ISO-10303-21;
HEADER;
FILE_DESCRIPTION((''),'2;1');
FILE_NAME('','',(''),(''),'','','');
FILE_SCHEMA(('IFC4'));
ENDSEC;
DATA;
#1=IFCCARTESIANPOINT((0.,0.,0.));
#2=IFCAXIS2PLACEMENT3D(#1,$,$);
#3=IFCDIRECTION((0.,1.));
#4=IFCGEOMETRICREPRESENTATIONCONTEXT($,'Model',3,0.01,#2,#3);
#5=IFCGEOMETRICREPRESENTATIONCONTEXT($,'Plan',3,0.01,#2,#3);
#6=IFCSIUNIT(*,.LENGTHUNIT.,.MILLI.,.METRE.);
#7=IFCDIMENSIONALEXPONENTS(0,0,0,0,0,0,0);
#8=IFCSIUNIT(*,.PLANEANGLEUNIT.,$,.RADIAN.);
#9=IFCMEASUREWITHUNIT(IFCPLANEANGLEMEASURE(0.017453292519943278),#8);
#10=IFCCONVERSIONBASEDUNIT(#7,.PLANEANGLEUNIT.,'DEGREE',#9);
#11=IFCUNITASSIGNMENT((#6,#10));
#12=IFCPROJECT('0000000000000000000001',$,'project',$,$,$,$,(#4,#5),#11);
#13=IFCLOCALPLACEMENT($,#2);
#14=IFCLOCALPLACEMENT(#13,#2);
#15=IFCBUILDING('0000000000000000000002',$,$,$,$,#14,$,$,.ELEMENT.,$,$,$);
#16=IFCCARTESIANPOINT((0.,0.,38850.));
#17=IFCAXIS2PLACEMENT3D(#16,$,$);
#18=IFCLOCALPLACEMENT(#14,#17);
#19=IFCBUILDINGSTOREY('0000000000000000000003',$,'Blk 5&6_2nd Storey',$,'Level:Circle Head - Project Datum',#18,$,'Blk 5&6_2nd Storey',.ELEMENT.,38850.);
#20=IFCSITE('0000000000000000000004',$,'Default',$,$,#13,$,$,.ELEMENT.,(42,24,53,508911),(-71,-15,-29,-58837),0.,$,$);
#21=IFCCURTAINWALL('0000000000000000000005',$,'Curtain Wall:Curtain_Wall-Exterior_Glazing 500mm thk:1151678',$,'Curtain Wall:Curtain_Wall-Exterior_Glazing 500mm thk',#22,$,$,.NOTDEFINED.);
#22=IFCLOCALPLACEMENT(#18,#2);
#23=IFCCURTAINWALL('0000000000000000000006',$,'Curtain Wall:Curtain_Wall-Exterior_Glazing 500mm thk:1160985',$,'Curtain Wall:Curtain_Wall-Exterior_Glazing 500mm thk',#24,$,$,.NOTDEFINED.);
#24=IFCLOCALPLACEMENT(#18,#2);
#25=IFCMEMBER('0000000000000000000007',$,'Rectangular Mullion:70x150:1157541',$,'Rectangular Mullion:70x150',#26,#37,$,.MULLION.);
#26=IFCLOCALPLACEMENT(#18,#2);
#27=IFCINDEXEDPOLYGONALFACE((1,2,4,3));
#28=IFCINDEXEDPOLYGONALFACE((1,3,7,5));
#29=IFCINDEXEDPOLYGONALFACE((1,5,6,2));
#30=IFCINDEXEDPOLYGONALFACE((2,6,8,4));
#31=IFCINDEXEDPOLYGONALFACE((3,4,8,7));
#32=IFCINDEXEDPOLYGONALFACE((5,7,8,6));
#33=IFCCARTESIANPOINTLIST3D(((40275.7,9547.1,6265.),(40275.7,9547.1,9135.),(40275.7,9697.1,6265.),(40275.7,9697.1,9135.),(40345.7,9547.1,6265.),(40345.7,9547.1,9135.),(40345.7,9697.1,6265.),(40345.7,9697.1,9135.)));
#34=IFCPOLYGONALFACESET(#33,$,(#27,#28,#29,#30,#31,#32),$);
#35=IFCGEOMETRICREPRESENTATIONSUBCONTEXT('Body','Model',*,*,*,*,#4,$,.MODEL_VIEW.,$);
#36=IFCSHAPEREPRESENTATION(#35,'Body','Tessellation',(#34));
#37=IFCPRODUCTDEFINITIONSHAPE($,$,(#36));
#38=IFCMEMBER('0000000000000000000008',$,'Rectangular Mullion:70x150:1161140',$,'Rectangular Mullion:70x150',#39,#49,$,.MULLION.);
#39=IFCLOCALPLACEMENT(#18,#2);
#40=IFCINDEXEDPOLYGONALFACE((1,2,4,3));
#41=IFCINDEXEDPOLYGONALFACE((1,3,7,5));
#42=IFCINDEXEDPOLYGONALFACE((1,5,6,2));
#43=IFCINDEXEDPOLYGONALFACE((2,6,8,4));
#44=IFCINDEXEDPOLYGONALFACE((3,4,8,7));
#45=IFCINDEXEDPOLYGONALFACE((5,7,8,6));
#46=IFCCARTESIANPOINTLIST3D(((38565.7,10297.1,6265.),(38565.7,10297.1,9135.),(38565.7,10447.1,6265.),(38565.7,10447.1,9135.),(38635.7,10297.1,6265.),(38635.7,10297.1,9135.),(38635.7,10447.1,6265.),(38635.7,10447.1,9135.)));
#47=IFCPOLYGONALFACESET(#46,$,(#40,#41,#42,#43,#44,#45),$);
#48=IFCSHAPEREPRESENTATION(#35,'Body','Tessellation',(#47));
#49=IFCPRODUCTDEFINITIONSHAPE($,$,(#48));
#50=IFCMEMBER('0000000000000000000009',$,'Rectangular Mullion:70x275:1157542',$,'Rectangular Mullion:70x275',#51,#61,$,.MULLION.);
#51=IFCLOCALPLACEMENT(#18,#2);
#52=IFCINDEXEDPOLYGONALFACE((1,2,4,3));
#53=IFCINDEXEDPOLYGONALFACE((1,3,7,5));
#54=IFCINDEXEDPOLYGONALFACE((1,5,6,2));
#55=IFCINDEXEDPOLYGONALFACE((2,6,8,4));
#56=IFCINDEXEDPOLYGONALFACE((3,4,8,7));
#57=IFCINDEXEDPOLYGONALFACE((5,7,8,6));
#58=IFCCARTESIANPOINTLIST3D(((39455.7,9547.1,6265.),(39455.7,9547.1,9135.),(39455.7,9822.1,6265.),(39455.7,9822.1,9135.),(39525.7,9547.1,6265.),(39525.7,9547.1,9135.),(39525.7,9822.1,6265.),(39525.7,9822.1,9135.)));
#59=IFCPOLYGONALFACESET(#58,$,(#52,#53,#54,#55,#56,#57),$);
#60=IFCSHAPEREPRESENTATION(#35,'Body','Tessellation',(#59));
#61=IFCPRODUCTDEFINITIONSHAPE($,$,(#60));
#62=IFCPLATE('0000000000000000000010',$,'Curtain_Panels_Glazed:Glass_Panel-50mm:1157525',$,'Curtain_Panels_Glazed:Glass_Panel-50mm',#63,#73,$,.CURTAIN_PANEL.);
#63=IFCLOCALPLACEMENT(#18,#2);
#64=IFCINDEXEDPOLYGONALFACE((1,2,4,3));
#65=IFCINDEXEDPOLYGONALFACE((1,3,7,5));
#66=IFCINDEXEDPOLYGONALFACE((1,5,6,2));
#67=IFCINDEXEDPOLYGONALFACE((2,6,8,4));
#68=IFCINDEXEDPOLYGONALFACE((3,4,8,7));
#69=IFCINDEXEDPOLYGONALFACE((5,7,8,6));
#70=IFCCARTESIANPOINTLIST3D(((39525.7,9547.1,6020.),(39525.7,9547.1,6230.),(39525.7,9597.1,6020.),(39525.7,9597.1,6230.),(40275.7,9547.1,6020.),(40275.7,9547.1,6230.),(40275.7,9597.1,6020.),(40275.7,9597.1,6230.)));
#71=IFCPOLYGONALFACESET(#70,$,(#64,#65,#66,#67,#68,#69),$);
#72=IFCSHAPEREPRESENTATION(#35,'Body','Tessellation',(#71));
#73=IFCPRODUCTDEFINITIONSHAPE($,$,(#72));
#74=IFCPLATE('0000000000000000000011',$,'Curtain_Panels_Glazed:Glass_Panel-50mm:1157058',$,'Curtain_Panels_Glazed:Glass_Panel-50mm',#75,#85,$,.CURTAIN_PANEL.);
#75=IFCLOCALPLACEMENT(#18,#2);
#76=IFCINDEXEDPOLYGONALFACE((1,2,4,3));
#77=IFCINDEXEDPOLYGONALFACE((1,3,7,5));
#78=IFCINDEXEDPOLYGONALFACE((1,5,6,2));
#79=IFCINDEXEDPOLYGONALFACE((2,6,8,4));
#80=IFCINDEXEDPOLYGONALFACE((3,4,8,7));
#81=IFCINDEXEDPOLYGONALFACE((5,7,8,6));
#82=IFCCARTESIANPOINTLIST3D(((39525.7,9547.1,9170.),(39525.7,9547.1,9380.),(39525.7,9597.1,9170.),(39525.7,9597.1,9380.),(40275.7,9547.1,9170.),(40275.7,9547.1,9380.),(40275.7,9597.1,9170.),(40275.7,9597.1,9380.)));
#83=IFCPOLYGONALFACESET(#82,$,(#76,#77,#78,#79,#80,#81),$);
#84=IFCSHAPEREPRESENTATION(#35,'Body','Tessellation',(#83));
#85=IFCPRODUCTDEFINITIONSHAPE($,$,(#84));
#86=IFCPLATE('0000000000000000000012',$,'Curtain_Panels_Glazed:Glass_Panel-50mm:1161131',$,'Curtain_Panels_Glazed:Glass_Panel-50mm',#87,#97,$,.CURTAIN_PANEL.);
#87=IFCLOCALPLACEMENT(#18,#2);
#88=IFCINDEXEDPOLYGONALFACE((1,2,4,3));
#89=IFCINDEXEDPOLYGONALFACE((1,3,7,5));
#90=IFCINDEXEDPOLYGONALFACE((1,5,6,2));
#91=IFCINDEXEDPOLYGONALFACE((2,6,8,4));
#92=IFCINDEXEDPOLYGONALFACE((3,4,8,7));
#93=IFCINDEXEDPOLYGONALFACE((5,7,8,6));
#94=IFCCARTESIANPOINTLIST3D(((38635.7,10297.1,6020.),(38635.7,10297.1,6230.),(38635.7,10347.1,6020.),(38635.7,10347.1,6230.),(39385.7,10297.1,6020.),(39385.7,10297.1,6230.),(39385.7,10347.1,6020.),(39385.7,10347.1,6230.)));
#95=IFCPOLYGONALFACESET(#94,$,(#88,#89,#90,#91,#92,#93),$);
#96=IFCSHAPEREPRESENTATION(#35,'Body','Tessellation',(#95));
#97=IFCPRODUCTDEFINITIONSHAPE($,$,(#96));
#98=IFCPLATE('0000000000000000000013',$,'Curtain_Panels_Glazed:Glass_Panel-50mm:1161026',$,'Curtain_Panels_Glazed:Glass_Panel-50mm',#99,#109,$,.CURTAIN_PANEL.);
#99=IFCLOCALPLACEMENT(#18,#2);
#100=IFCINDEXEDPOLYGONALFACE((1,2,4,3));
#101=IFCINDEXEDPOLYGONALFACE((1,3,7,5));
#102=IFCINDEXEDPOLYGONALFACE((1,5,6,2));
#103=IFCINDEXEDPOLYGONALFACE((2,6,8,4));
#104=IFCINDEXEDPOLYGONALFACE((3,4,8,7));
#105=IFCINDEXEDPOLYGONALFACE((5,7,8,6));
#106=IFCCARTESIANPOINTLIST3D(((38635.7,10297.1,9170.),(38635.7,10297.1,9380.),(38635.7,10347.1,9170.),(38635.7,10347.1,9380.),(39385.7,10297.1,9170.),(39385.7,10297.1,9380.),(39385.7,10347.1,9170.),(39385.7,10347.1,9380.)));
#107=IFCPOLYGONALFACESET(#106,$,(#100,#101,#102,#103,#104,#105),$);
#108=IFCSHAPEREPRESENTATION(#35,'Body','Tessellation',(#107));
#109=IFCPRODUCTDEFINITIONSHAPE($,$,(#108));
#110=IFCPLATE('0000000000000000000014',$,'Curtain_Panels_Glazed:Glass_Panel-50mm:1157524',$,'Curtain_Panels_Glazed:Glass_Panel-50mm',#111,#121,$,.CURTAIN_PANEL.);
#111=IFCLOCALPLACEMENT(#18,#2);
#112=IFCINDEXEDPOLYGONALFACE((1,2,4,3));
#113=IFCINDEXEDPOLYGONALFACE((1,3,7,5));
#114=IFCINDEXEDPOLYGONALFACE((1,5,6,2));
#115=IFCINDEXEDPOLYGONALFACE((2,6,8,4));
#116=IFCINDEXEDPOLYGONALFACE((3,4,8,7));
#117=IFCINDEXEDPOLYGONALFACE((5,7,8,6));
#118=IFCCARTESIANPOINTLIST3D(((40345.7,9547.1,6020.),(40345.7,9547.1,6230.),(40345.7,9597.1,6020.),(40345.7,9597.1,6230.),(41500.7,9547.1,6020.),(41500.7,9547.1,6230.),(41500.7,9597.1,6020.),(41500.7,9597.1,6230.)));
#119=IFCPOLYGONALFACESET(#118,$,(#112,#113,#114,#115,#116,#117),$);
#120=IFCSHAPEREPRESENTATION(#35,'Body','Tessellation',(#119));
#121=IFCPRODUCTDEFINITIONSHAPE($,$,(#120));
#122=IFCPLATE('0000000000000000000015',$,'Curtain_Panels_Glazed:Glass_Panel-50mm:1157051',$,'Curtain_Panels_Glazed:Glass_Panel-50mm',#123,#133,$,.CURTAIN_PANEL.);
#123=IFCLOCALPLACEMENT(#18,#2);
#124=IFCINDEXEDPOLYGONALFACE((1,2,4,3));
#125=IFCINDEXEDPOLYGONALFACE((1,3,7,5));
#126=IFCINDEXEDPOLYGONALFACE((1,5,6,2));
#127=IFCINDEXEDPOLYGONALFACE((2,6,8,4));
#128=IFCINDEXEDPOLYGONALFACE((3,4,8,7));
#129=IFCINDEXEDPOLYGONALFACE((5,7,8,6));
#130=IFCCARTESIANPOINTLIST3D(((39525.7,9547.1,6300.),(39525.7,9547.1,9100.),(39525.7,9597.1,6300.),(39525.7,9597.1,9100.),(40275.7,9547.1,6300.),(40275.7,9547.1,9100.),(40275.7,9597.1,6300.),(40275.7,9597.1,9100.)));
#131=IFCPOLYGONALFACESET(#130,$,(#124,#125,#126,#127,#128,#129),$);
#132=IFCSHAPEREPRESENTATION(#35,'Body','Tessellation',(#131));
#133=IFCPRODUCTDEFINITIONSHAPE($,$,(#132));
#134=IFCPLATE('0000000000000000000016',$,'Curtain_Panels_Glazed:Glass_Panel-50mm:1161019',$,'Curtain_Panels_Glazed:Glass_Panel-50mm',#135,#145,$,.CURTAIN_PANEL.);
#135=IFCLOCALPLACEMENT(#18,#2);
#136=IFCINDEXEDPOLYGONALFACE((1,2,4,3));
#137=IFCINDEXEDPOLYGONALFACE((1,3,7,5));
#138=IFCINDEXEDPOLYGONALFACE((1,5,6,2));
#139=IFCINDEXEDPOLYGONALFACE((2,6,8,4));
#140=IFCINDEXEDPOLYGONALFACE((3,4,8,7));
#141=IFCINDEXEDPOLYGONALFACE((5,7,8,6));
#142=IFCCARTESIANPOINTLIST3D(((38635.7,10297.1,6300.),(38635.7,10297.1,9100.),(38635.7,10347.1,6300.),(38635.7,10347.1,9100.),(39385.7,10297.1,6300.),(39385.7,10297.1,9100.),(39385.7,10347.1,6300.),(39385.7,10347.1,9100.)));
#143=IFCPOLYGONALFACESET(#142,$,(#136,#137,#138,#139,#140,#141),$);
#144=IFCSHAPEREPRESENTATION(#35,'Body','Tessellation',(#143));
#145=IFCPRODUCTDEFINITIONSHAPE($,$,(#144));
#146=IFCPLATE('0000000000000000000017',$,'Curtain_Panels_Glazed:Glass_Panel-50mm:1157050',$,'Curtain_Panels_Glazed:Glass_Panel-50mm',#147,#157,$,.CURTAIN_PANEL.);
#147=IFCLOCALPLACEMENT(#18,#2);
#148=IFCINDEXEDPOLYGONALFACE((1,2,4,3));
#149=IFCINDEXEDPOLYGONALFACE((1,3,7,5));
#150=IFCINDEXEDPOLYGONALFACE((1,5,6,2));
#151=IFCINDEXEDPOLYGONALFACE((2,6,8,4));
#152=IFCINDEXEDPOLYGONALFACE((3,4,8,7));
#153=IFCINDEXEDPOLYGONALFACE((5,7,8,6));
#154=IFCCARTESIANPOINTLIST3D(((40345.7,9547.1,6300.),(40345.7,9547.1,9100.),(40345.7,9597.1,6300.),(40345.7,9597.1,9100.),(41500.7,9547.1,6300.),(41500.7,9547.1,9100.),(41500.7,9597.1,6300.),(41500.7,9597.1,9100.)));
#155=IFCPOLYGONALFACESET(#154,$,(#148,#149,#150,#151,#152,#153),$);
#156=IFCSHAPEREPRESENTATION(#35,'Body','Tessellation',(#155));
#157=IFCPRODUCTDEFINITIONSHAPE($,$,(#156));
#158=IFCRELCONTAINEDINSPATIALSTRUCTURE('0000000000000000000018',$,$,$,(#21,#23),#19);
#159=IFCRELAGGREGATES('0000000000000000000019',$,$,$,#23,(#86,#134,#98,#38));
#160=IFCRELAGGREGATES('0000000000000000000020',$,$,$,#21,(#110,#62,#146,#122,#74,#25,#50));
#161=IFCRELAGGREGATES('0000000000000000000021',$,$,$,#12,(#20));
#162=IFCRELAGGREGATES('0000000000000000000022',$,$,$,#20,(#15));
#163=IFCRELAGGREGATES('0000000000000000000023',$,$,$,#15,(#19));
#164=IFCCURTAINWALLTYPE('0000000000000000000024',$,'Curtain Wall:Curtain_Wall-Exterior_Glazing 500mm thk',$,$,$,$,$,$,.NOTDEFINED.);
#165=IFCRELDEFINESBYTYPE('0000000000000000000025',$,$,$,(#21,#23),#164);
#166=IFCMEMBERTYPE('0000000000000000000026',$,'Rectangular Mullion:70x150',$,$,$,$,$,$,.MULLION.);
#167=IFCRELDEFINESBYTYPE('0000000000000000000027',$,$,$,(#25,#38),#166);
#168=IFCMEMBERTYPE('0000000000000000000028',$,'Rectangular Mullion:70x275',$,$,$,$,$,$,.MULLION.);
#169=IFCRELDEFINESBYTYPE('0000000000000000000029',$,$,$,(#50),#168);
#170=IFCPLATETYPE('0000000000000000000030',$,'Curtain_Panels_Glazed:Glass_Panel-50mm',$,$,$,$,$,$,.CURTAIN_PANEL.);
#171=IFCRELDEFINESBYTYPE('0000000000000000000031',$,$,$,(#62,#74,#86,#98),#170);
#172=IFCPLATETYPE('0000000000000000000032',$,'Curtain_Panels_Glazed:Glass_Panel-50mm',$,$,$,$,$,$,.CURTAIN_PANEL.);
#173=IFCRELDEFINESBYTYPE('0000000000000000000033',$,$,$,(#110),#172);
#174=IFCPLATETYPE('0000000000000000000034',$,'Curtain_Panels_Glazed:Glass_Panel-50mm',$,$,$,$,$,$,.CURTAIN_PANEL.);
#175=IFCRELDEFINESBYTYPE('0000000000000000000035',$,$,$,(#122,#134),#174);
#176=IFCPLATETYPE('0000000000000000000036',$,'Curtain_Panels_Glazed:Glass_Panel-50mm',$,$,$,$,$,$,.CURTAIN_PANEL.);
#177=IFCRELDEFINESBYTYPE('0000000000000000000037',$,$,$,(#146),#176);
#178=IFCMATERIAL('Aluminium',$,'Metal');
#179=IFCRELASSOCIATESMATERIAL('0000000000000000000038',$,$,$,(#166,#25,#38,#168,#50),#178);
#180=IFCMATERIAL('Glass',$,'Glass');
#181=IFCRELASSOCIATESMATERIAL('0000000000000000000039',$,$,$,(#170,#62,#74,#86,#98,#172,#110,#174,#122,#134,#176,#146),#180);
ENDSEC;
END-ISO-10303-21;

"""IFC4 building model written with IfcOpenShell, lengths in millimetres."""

from ifc_helpers import new_model, entity, si_unit, converted_unit, direction, frame, origin, place, context, subcontext, project, spatial, indexed_curve, outline, extrude, source, transform, mapped, material, type_object, type_shapes, element, aggregate, save


model = new_model("IFC4")

# Units and contexts
model_context = context("Model", 3, precision=0.01, world=origin(), true_north=direction((0.0, 1.0)))
plan_context = context("Plan", 3, precision=0.01, world=origin(), true_north=direction((0.0, 1.0)))
body_context = subcontext(model_context, "Body", "Model", "MODEL_VIEW")
ifc_project = project(units=[si_unit("LENGTHUNIT", "METRE", prefix="MILLI"), converted_unit("PLANEANGLEUNIT", "DEGREE", entity("IfcPlaneAngleMeasure", 0.017453292519943278), si_unit("PLANEANGLEUNIT", "RADIAN"), dimensions=[0, 0, 0, 0, 0, 0, 0])], contexts=[model_context, plan_context])

# Site, building, storey
site_placement = place(None, origin())
site = spatial("IfcSite", under=ifc_project, at=site_placement, Name="Default", CompositionType="ELEMENT", RefLatitude=(42, 24, 53, 508911), RefLongitude=(-71, -15, -29, -58837), RefElevation=0.0)
building_placement = place(site_placement, origin())
building = spatial("IfcBuilding", under=site, at=building_placement, CompositionType="ELEMENT")
storey_placement = place(building_placement, frame((0.0, 0.0, 38850.0)))
storey = spatial("IfcBuildingStorey", under=building, at=storey_placement, Name="Blk 5&6_2nd Storey", ObjectType="Level:Circle Head - Project Datum", LongName="Blk 5&6_2nd Storey", CompositionType="ELEMENT", Elevation=38850.0)

# Curtain walls
curtain_wall_type = type_object("IfcCurtainWallType", Name="Curtain Wall:Curtain_Wall-Exterior_Glazing 500mm thk", PredefinedType="NOTDEFINED")
curtain_wall_1_placement = place(storey_placement, frame((0.0, 0.0, -38850.0)))
curtain_wall_1 = element("IfcCurtainWall", 1, at=curtain_wall_1_placement, inside=storey, type_object=curtain_wall_type, Name="Curtain Wall:Curtain_Wall-Exterior_Glazing 500mm thk:1151678", ObjectType="Curtain Wall:Curtain_Wall-Exterior_Glazing 500mm thk", PredefinedType="NOTDEFINED")
ifc_material_1 = material(Name="Aluminium", Category="Metal")
curtain_wall_2_placement = place(storey_placement, frame((0.0, 0.0, -38850.0)))
curtain_wall_2 = element("IfcCurtainWall", 2, at=curtain_wall_2_placement, inside=storey, type_object=curtain_wall_type, Name="Curtain Wall:Curtain_Wall-Exterior_Glazing 500mm thk:1160985", ObjectType="Curtain Wall:Curtain_Wall-Exterior_Glazing 500mm thk", PredefinedType="NOTDEFINED")

# Members
member_type_1 = type_object("IfcMemberType", Name="Rectangular Mullion:70x150", PredefinedType="MULLION", material=ifc_material_1)
shared_shape_1 = source(origin(), body_context, "Body", "SweptSolid", [
    extrude(outline(indexed_curve([(-35.0, -75.0), (35.0, -75.0), (35.0, 75.0), (-35.0, 75.0), (-35.0, -75.0)], self_intersect=False)), frame((0.0, -200.0, -2870.0), z_axis=(0.0, 0.0, 1.0), x_axis=(-1.0, 0.0, 0.0)), (0.0, 0.0, 1.0), 2870.0),
])
type_shapes(member_type_1, [shared_shape_1])
member_1_placement = place(curtain_wall_1_placement, frame((40310.7, 9822.1, 45115.0), z_axis=(0.0, 0.0, -1.0), x_axis=(-1.0, 0.0, 0.0)))
member_1 = element("IfcMember", 3, at=member_1_placement, type_object=member_type_1, material=ifc_material_1, Name="Rectangular Mullion:70x150:1157541", ObjectType="Rectangular Mullion:70x150", PredefinedType="MULLION", context=body_context, shape_type="MappedRepresentation", body=[
    mapped(shared_shape_1, transform((0.0, 0.0, 0.0), scale=1.0)),
])
member_2_placement = place(curtain_wall_2_placement, frame((38600.7, 10572.1, 45115.0), z_axis=(0.0, 0.0, -1.0), x_axis=(-1.0, 0.0, 0.0)))
member_2 = element("IfcMember", 4, at=member_2_placement, type_object=member_type_1, material=ifc_material_1, Name="Rectangular Mullion:70x150:1161140", ObjectType="Rectangular Mullion:70x150", PredefinedType="MULLION", context=body_context, shape_type="MappedRepresentation", body=[
    mapped(shared_shape_1, transform((0.0, 0.0, 0.0), scale=1.0)),
])
member_type_2 = type_object("IfcMemberType", Name="Rectangular Mullion:70x275", PredefinedType="MULLION", material=ifc_material_1)
shared_shape_2 = source(origin(), body_context, "Body", "SweptSolid", [
    extrude(outline(indexed_curve([(-35.0, -137.5), (35.0, -137.5), (35.0, 137.5), (-35.0, 137.5), (-35.0, -137.5)], self_intersect=False)), frame((-35.0, -137.5, -2870.0), z_axis=(0.0, 0.0, 1.0), x_axis=(-1.0, 0.0, 0.0)), (0.0, 0.0, 1.0), 2870.0),
])
type_shapes(member_type_2, [shared_shape_2])
member_3_placement = place(curtain_wall_1_placement, frame((39455.7, 9822.1, 45115.0), z_axis=(0.0, 0.0, -1.0), x_axis=(-1.0, 0.0, 0.0)))
member_3 = element("IfcMember", 5, at=member_3_placement, type_object=member_type_2, material=ifc_material_1, Name="Rectangular Mullion:70x275:1157542", ObjectType="Rectangular Mullion:70x275", PredefinedType="MULLION", context=body_context, shape_type="MappedRepresentation", body=[
    mapped(shared_shape_2, transform((0.0, 0.0, 0.0), scale=1.0)),
])

# Plates
ifc_material_2 = material(Name="Glass", Category="Glass")
plate_type_1 = type_object("IfcPlateType", Name="Curtain_Panels_Glazed:Glass_Panel-50mm", PredefinedType="CURTAIN_PANEL", material=ifc_material_2)
shared_shape_3 = source(origin(), body_context, "Body", "SweptSolid", [
    extrude(outline(indexed_curve([(-25.0, -375.0), (25.0, -375.0), (25.0, 375.0), (-25.0, 375.0), (-25.0, -375.0)], self_intersect=False)), frame((0.0, 250.0, 0.0), z_axis=(0.0, 0.0, 1.0), x_axis=(0.0, 1.0, 0.0)), (0.0, 0.0, 1.0), 210.0),
])
type_shapes(plate_type_1, [shared_shape_3])
plate_1_placement = place(curtain_wall_1_placement, frame((39900.7, 9822.1, 44870.0), z_axis=(0.0, 0.0, 1.0), x_axis=(-1.0, 0.0, 0.0)))
plate_1 = element("IfcPlate", 6, at=plate_1_placement, type_object=plate_type_1, material=ifc_material_2, Name="Curtain_Panels_Glazed:Glass_Panel-50mm:1157525", ObjectType="Curtain_Panels_Glazed:Glass_Panel-50mm", PredefinedType="CURTAIN_PANEL", context=body_context, shape_type="MappedRepresentation", body=[
    mapped(shared_shape_3, transform((0.0, 0.0, 0.0), scale=1.0)),
])
plate_2_placement = place(curtain_wall_1_placement, frame((39900.7, 9822.1, 48020.0), z_axis=(0.0, 0.0, 1.0), x_axis=(-1.0, 0.0, 0.0)))
plate_2 = element("IfcPlate", 7, at=plate_2_placement, type_object=plate_type_1, material=ifc_material_2, Name="Curtain_Panels_Glazed:Glass_Panel-50mm:1157058", ObjectType="Curtain_Panels_Glazed:Glass_Panel-50mm", PredefinedType="CURTAIN_PANEL", context=body_context, shape_type="MappedRepresentation", body=[
    mapped(shared_shape_3, transform((0.0, 0.0, 0.0), scale=1.0)),
])
plate_3_placement = place(curtain_wall_2_placement, frame((39010.7, 10572.1, 44870.0), z_axis=(0.0, 0.0, 1.0), x_axis=(-1.0, 0.0, 0.0)))
plate_3 = element("IfcPlate", 8, at=plate_3_placement, type_object=plate_type_1, material=ifc_material_2, Name="Curtain_Panels_Glazed:Glass_Panel-50mm:1161131", ObjectType="Curtain_Panels_Glazed:Glass_Panel-50mm", PredefinedType="CURTAIN_PANEL", context=body_context, shape_type="MappedRepresentation", body=[
    mapped(shared_shape_3, transform((0.0, 0.0, 0.0), scale=1.0)),
])
plate_4_placement = place(curtain_wall_2_placement, frame((39010.7, 10572.1, 48020.0), z_axis=(0.0, 0.0, 1.0), x_axis=(-1.0, 0.0, 0.0)))
plate_4 = element("IfcPlate", 9, at=plate_4_placement, type_object=plate_type_1, material=ifc_material_2, Name="Curtain_Panels_Glazed:Glass_Panel-50mm:1161026", ObjectType="Curtain_Panels_Glazed:Glass_Panel-50mm", PredefinedType="CURTAIN_PANEL", context=body_context, shape_type="MappedRepresentation", body=[
    mapped(shared_shape_3, transform((0.0, 0.0, 0.0), scale=1.0)),
])
plate_type_2 = type_object("IfcPlateType", Name="Curtain_Panels_Glazed:Glass_Panel-50mm", PredefinedType="CURTAIN_PANEL", material=ifc_material_2)
shared_shape_4 = source(origin(), body_context, "Body", "SweptSolid", [
    extrude(outline(indexed_curve([(-25.0, -577.5), (25.0, -577.5), (25.0, 577.5), (-25.0, 577.5), (-25.0, -577.5)], self_intersect=False)), frame((0.0, 250.0, 0.0), z_axis=(0.0, 0.0, 1.0), x_axis=(0.0, 1.0, 0.0)), (0.0, 0.0, 1.0), 210.0),
])
type_shapes(plate_type_2, [shared_shape_4])
plate_5_placement = place(curtain_wall_1_placement, frame((40923.2, 9822.1, 44870.0), z_axis=(0.0, 0.0, 1.0), x_axis=(-1.0, 0.0, 0.0)))
plate_5 = element("IfcPlate", 10, at=plate_5_placement, type_object=plate_type_2, material=ifc_material_2, Name="Curtain_Panels_Glazed:Glass_Panel-50mm:1157524", ObjectType="Curtain_Panels_Glazed:Glass_Panel-50mm", PredefinedType="CURTAIN_PANEL", context=body_context, shape_type="MappedRepresentation", body=[
    mapped(shared_shape_4, transform((0.0, 0.0, 0.0), scale=1.0)),
])
plate_type_3 = type_object("IfcPlateType", Name="Curtain_Panels_Glazed:Glass_Panel-50mm", PredefinedType="CURTAIN_PANEL", material=ifc_material_2)
shared_shape_5 = source(origin(), body_context, "Body", "SweptSolid", [
    extrude(outline(indexed_curve([(-25.0, -375.0), (25.0, -375.0), (25.0, 375.0), (-25.0, 375.0), (-25.0, -375.0)], self_intersect=False)), frame((0.0, 250.0, 0.0), z_axis=(0.0, 0.0, 1.0), x_axis=(0.0, 1.0, 0.0)), (0.0, 0.0, 1.0), 2800.0),
])
type_shapes(plate_type_3, [shared_shape_5])
plate_6_placement = place(curtain_wall_1_placement, frame((39900.7, 9822.1, 45150.0), z_axis=(0.0, 0.0, 1.0), x_axis=(-1.0, 0.0, 0.0)))
plate_6 = element("IfcPlate", 11, at=plate_6_placement, type_object=plate_type_3, material=ifc_material_2, Name="Curtain_Panels_Glazed:Glass_Panel-50mm:1157051", ObjectType="Curtain_Panels_Glazed:Glass_Panel-50mm", PredefinedType="CURTAIN_PANEL", context=body_context, shape_type="MappedRepresentation", body=[
    mapped(shared_shape_5, transform((0.0, 0.0, 0.0), scale=1.0)),
])
plate_7_placement = place(curtain_wall_2_placement, frame((39010.7, 10572.1, 45150.0), z_axis=(0.0, 0.0, 1.0), x_axis=(-1.0, 0.0, 0.0)))
plate_7 = element("IfcPlate", 12, at=plate_7_placement, type_object=plate_type_3, material=ifc_material_2, Name="Curtain_Panels_Glazed:Glass_Panel-50mm:1161019", ObjectType="Curtain_Panels_Glazed:Glass_Panel-50mm", PredefinedType="CURTAIN_PANEL", context=body_context, shape_type="MappedRepresentation", body=[
    mapped(shared_shape_5, transform((0.0, 0.0, 0.0), scale=1.0)),
])
aggregate(curtain_wall_2, [plate_3, plate_7, plate_4, member_2])
plate_type_4 = type_object("IfcPlateType", Name="Curtain_Panels_Glazed:Glass_Panel-50mm", PredefinedType="CURTAIN_PANEL", material=ifc_material_2)
shared_shape_6 = source(origin(), body_context, "Body", "SweptSolid", [
    extrude(outline(indexed_curve([(-25.0, -577.5), (25.0, -577.5), (25.0, 577.5), (-25.0, 577.5), (-25.0, -577.5)], self_intersect=False)), frame((0.0, 250.0, 0.0), z_axis=(0.0, 0.0, 1.0), x_axis=(0.0, 1.0, 0.0)), (0.0, 0.0, 1.0), 2800.0),
])
type_shapes(plate_type_4, [shared_shape_6])
plate_8_placement = place(curtain_wall_1_placement, frame((40923.2, 9822.1, 45150.0), z_axis=(0.0, 0.0, 1.0), x_axis=(-1.0, 0.0, 0.0)))
plate_8 = element("IfcPlate", 13, at=plate_8_placement, type_object=plate_type_4, material=ifc_material_2, Name="Curtain_Panels_Glazed:Glass_Panel-50mm:1157050", ObjectType="Curtain_Panels_Glazed:Glass_Panel-50mm", PredefinedType="CURTAIN_PANEL", context=body_context, shape_type="MappedRepresentation", body=[
    mapped(shared_shape_6, transform((0.0, 0.0, 0.0), scale=1.0)),
])
aggregate(curtain_wall_1, [plate_5, plate_1, plate_8, plate_6, plate_2, member_1, member_3])

save(model, "model.ifc")
